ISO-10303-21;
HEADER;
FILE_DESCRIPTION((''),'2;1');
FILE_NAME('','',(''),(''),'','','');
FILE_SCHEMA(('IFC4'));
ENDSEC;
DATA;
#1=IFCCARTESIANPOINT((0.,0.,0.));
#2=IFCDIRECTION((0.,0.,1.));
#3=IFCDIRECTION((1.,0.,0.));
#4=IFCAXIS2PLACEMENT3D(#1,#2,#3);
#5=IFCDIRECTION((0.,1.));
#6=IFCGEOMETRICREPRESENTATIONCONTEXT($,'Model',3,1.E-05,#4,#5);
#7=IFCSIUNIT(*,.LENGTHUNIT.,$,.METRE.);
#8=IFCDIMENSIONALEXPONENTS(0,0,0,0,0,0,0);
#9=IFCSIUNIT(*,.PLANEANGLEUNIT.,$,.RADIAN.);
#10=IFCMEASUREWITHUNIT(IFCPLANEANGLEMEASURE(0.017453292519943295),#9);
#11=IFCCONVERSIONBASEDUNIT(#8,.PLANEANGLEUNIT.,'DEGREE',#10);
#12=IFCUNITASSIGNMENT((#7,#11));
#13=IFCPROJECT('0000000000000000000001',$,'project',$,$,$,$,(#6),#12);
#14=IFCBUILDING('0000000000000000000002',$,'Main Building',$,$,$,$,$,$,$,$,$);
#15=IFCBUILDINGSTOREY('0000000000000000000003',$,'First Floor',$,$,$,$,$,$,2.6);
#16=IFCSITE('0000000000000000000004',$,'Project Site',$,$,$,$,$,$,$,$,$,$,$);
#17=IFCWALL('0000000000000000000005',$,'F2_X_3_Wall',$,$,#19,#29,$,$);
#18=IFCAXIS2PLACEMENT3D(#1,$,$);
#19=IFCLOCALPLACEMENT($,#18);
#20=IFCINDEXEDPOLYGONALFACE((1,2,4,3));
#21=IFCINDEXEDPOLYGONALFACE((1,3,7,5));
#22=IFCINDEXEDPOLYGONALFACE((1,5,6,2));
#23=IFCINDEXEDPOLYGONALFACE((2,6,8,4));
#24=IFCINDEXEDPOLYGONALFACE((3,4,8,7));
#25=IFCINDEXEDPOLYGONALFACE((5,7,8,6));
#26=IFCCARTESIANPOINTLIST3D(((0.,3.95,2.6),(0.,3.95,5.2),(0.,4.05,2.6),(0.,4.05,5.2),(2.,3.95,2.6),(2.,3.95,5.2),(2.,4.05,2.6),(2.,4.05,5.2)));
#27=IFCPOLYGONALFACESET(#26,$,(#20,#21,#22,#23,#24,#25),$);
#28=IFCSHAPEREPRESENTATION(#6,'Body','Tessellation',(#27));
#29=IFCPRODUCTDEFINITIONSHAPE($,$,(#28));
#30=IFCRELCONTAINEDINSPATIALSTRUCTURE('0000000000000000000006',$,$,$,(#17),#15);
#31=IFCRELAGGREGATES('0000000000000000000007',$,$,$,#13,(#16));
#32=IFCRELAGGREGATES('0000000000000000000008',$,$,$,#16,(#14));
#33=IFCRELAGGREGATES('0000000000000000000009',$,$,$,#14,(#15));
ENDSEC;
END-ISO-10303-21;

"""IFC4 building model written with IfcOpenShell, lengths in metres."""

from ifc_helpers import new_model, entity, si_unit, converted_unit, direction, frame, frame_2d, origin, origin_with_axes, place, context, project, spatial, rectangle, extrude, element, save


model = new_model("IFC4")

# Units and contexts
model_context = context("Model", 3, precision=1e-05, world=origin_with_axes(), true_north=direction((0.0, 1.0)))
ifc_project = project(units=[si_unit("LENGTHUNIT", "METRE"), converted_unit("PLANEANGLEUNIT", "DEGREE", entity("IfcPlaneAngleMeasure", 0.017453292519943295), si_unit("PLANEANGLEUNIT", "RADIAN"), dimensions=[0, 0, 0, 0, 0, 0, 0])], contexts=[model_context])

# Site, building, storey
site = spatial("IfcSite", under=ifc_project, Name="Project Site")
building = spatial("IfcBuilding", under=site, Name="Main Building")
storey = spatial("IfcBuildingStorey", under=building, Name="First Floor", Elevation=2.6)

# Wall
wall_1_placement = place(None, frame((0.0, 4.0, 2.6), z_axis=(0.0, 0.0, 1.0), x_axis=(1.0, 0.0, 0.0)))
element("IfcWall", 1, at=wall_1_placement, inside=storey, Name="F2_X_3_Wall", context=model_context, shape_type="SweptSolid", body=[
    extrude(rectangle(XDim=2.0, YDim=0.1, at=frame_2d((1.0, 0.0))), origin(), (0.0, 0.0, 1.0), 2.6),
])

save(model, "model.ifc")
